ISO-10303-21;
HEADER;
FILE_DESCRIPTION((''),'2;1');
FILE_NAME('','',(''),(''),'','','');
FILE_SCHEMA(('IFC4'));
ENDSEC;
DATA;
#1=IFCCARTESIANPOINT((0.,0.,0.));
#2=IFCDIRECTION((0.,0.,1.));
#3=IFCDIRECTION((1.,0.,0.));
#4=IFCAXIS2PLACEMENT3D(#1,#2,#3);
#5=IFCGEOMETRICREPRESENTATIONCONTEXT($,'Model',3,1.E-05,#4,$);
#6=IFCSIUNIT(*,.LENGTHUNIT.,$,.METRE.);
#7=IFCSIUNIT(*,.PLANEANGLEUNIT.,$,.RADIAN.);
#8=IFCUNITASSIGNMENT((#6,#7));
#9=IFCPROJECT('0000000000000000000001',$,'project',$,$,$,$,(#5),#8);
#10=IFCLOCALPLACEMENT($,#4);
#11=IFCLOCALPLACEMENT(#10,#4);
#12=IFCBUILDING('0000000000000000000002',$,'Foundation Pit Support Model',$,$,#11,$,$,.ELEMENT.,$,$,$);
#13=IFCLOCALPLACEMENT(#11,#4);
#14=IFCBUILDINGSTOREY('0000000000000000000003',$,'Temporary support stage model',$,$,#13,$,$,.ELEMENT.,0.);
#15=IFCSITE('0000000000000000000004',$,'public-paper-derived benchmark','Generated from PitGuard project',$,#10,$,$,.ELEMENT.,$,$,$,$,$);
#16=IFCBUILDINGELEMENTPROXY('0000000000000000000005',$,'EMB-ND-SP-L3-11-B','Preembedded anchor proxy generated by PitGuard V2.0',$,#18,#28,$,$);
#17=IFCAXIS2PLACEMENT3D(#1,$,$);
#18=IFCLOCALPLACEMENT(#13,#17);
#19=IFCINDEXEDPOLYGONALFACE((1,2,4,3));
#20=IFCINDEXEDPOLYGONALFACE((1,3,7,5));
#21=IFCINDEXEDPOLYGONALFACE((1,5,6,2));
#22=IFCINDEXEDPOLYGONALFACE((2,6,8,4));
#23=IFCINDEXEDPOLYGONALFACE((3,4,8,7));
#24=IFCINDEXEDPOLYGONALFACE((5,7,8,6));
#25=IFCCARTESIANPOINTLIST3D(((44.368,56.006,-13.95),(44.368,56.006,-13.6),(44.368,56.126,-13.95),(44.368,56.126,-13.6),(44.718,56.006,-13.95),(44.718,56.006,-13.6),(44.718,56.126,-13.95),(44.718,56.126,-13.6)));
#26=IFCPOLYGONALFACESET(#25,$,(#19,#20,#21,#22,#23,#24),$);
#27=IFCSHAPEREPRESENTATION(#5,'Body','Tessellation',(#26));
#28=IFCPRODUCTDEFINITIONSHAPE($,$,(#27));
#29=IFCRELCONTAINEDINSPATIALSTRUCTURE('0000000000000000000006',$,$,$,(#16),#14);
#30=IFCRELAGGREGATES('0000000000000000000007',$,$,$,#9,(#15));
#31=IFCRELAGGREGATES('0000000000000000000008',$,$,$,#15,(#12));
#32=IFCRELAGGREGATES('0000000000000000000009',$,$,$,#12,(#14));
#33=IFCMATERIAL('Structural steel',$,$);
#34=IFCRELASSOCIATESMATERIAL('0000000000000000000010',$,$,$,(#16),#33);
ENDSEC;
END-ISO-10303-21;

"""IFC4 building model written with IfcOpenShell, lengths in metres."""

from ifc_helpers import new_model, si_unit, frame, origin_with_axes, origin_2d, place, context, project, spatial, rectangle, extrude, material, element, save


model = new_model("IFC4")

# Units and contexts
model_context = context("Model", 3, precision=1e-05, world=origin_with_axes())
ifc_project = project(units=[si_unit("LENGTHUNIT", "METRE"), si_unit("PLANEANGLEUNIT", "RADIAN")], contexts=[model_context])

# Site, building, storey
site_placement = place(None, origin_with_axes())
site = spatial("IfcSite", under=ifc_project, at=site_placement, Name="public-paper-derived benchmark", Description="Generated from PitGuard project", CompositionType="ELEMENT")
building_placement = place(site_placement, origin_with_axes())
building = spatial("IfcBuilding", under=site, at=building_placement, Name="Foundation Pit Support Model", CompositionType="ELEMENT")
storey_placement = place(building_placement, origin_with_axes())
storey = spatial("IfcBuildingStorey", under=building, at=storey_placement, Name="Temporary support stage model", CompositionType="ELEMENT", Elevation=0.0)

# Shared definitions
ifc_material_1 = material(Name="Structural steel")

# Building element proxy
proxy_1_placement = place(storey_placement, frame((44.543, 56.066, -13.95), z_axis=(0.0, 0.0, 1.0), x_axis=(1.0, 0.0, 0.0)))
element("IfcBuildingElementProxy", 1, at=proxy_1_placement, inside=storey, material=ifc_material_1, Name="EMB-ND-SP-L3-11-B", Description="Preembedded anchor proxy generated by PitGuard V2.0", context=model_context, shape_type="SweptSolid", body=[
    extrude(rectangle(XDim=0.35, YDim=0.12, at=origin_2d()), origin_with_axes(), (0.0, 0.0, 1.0), 0.35),
])

save(model, "model.ifc")
